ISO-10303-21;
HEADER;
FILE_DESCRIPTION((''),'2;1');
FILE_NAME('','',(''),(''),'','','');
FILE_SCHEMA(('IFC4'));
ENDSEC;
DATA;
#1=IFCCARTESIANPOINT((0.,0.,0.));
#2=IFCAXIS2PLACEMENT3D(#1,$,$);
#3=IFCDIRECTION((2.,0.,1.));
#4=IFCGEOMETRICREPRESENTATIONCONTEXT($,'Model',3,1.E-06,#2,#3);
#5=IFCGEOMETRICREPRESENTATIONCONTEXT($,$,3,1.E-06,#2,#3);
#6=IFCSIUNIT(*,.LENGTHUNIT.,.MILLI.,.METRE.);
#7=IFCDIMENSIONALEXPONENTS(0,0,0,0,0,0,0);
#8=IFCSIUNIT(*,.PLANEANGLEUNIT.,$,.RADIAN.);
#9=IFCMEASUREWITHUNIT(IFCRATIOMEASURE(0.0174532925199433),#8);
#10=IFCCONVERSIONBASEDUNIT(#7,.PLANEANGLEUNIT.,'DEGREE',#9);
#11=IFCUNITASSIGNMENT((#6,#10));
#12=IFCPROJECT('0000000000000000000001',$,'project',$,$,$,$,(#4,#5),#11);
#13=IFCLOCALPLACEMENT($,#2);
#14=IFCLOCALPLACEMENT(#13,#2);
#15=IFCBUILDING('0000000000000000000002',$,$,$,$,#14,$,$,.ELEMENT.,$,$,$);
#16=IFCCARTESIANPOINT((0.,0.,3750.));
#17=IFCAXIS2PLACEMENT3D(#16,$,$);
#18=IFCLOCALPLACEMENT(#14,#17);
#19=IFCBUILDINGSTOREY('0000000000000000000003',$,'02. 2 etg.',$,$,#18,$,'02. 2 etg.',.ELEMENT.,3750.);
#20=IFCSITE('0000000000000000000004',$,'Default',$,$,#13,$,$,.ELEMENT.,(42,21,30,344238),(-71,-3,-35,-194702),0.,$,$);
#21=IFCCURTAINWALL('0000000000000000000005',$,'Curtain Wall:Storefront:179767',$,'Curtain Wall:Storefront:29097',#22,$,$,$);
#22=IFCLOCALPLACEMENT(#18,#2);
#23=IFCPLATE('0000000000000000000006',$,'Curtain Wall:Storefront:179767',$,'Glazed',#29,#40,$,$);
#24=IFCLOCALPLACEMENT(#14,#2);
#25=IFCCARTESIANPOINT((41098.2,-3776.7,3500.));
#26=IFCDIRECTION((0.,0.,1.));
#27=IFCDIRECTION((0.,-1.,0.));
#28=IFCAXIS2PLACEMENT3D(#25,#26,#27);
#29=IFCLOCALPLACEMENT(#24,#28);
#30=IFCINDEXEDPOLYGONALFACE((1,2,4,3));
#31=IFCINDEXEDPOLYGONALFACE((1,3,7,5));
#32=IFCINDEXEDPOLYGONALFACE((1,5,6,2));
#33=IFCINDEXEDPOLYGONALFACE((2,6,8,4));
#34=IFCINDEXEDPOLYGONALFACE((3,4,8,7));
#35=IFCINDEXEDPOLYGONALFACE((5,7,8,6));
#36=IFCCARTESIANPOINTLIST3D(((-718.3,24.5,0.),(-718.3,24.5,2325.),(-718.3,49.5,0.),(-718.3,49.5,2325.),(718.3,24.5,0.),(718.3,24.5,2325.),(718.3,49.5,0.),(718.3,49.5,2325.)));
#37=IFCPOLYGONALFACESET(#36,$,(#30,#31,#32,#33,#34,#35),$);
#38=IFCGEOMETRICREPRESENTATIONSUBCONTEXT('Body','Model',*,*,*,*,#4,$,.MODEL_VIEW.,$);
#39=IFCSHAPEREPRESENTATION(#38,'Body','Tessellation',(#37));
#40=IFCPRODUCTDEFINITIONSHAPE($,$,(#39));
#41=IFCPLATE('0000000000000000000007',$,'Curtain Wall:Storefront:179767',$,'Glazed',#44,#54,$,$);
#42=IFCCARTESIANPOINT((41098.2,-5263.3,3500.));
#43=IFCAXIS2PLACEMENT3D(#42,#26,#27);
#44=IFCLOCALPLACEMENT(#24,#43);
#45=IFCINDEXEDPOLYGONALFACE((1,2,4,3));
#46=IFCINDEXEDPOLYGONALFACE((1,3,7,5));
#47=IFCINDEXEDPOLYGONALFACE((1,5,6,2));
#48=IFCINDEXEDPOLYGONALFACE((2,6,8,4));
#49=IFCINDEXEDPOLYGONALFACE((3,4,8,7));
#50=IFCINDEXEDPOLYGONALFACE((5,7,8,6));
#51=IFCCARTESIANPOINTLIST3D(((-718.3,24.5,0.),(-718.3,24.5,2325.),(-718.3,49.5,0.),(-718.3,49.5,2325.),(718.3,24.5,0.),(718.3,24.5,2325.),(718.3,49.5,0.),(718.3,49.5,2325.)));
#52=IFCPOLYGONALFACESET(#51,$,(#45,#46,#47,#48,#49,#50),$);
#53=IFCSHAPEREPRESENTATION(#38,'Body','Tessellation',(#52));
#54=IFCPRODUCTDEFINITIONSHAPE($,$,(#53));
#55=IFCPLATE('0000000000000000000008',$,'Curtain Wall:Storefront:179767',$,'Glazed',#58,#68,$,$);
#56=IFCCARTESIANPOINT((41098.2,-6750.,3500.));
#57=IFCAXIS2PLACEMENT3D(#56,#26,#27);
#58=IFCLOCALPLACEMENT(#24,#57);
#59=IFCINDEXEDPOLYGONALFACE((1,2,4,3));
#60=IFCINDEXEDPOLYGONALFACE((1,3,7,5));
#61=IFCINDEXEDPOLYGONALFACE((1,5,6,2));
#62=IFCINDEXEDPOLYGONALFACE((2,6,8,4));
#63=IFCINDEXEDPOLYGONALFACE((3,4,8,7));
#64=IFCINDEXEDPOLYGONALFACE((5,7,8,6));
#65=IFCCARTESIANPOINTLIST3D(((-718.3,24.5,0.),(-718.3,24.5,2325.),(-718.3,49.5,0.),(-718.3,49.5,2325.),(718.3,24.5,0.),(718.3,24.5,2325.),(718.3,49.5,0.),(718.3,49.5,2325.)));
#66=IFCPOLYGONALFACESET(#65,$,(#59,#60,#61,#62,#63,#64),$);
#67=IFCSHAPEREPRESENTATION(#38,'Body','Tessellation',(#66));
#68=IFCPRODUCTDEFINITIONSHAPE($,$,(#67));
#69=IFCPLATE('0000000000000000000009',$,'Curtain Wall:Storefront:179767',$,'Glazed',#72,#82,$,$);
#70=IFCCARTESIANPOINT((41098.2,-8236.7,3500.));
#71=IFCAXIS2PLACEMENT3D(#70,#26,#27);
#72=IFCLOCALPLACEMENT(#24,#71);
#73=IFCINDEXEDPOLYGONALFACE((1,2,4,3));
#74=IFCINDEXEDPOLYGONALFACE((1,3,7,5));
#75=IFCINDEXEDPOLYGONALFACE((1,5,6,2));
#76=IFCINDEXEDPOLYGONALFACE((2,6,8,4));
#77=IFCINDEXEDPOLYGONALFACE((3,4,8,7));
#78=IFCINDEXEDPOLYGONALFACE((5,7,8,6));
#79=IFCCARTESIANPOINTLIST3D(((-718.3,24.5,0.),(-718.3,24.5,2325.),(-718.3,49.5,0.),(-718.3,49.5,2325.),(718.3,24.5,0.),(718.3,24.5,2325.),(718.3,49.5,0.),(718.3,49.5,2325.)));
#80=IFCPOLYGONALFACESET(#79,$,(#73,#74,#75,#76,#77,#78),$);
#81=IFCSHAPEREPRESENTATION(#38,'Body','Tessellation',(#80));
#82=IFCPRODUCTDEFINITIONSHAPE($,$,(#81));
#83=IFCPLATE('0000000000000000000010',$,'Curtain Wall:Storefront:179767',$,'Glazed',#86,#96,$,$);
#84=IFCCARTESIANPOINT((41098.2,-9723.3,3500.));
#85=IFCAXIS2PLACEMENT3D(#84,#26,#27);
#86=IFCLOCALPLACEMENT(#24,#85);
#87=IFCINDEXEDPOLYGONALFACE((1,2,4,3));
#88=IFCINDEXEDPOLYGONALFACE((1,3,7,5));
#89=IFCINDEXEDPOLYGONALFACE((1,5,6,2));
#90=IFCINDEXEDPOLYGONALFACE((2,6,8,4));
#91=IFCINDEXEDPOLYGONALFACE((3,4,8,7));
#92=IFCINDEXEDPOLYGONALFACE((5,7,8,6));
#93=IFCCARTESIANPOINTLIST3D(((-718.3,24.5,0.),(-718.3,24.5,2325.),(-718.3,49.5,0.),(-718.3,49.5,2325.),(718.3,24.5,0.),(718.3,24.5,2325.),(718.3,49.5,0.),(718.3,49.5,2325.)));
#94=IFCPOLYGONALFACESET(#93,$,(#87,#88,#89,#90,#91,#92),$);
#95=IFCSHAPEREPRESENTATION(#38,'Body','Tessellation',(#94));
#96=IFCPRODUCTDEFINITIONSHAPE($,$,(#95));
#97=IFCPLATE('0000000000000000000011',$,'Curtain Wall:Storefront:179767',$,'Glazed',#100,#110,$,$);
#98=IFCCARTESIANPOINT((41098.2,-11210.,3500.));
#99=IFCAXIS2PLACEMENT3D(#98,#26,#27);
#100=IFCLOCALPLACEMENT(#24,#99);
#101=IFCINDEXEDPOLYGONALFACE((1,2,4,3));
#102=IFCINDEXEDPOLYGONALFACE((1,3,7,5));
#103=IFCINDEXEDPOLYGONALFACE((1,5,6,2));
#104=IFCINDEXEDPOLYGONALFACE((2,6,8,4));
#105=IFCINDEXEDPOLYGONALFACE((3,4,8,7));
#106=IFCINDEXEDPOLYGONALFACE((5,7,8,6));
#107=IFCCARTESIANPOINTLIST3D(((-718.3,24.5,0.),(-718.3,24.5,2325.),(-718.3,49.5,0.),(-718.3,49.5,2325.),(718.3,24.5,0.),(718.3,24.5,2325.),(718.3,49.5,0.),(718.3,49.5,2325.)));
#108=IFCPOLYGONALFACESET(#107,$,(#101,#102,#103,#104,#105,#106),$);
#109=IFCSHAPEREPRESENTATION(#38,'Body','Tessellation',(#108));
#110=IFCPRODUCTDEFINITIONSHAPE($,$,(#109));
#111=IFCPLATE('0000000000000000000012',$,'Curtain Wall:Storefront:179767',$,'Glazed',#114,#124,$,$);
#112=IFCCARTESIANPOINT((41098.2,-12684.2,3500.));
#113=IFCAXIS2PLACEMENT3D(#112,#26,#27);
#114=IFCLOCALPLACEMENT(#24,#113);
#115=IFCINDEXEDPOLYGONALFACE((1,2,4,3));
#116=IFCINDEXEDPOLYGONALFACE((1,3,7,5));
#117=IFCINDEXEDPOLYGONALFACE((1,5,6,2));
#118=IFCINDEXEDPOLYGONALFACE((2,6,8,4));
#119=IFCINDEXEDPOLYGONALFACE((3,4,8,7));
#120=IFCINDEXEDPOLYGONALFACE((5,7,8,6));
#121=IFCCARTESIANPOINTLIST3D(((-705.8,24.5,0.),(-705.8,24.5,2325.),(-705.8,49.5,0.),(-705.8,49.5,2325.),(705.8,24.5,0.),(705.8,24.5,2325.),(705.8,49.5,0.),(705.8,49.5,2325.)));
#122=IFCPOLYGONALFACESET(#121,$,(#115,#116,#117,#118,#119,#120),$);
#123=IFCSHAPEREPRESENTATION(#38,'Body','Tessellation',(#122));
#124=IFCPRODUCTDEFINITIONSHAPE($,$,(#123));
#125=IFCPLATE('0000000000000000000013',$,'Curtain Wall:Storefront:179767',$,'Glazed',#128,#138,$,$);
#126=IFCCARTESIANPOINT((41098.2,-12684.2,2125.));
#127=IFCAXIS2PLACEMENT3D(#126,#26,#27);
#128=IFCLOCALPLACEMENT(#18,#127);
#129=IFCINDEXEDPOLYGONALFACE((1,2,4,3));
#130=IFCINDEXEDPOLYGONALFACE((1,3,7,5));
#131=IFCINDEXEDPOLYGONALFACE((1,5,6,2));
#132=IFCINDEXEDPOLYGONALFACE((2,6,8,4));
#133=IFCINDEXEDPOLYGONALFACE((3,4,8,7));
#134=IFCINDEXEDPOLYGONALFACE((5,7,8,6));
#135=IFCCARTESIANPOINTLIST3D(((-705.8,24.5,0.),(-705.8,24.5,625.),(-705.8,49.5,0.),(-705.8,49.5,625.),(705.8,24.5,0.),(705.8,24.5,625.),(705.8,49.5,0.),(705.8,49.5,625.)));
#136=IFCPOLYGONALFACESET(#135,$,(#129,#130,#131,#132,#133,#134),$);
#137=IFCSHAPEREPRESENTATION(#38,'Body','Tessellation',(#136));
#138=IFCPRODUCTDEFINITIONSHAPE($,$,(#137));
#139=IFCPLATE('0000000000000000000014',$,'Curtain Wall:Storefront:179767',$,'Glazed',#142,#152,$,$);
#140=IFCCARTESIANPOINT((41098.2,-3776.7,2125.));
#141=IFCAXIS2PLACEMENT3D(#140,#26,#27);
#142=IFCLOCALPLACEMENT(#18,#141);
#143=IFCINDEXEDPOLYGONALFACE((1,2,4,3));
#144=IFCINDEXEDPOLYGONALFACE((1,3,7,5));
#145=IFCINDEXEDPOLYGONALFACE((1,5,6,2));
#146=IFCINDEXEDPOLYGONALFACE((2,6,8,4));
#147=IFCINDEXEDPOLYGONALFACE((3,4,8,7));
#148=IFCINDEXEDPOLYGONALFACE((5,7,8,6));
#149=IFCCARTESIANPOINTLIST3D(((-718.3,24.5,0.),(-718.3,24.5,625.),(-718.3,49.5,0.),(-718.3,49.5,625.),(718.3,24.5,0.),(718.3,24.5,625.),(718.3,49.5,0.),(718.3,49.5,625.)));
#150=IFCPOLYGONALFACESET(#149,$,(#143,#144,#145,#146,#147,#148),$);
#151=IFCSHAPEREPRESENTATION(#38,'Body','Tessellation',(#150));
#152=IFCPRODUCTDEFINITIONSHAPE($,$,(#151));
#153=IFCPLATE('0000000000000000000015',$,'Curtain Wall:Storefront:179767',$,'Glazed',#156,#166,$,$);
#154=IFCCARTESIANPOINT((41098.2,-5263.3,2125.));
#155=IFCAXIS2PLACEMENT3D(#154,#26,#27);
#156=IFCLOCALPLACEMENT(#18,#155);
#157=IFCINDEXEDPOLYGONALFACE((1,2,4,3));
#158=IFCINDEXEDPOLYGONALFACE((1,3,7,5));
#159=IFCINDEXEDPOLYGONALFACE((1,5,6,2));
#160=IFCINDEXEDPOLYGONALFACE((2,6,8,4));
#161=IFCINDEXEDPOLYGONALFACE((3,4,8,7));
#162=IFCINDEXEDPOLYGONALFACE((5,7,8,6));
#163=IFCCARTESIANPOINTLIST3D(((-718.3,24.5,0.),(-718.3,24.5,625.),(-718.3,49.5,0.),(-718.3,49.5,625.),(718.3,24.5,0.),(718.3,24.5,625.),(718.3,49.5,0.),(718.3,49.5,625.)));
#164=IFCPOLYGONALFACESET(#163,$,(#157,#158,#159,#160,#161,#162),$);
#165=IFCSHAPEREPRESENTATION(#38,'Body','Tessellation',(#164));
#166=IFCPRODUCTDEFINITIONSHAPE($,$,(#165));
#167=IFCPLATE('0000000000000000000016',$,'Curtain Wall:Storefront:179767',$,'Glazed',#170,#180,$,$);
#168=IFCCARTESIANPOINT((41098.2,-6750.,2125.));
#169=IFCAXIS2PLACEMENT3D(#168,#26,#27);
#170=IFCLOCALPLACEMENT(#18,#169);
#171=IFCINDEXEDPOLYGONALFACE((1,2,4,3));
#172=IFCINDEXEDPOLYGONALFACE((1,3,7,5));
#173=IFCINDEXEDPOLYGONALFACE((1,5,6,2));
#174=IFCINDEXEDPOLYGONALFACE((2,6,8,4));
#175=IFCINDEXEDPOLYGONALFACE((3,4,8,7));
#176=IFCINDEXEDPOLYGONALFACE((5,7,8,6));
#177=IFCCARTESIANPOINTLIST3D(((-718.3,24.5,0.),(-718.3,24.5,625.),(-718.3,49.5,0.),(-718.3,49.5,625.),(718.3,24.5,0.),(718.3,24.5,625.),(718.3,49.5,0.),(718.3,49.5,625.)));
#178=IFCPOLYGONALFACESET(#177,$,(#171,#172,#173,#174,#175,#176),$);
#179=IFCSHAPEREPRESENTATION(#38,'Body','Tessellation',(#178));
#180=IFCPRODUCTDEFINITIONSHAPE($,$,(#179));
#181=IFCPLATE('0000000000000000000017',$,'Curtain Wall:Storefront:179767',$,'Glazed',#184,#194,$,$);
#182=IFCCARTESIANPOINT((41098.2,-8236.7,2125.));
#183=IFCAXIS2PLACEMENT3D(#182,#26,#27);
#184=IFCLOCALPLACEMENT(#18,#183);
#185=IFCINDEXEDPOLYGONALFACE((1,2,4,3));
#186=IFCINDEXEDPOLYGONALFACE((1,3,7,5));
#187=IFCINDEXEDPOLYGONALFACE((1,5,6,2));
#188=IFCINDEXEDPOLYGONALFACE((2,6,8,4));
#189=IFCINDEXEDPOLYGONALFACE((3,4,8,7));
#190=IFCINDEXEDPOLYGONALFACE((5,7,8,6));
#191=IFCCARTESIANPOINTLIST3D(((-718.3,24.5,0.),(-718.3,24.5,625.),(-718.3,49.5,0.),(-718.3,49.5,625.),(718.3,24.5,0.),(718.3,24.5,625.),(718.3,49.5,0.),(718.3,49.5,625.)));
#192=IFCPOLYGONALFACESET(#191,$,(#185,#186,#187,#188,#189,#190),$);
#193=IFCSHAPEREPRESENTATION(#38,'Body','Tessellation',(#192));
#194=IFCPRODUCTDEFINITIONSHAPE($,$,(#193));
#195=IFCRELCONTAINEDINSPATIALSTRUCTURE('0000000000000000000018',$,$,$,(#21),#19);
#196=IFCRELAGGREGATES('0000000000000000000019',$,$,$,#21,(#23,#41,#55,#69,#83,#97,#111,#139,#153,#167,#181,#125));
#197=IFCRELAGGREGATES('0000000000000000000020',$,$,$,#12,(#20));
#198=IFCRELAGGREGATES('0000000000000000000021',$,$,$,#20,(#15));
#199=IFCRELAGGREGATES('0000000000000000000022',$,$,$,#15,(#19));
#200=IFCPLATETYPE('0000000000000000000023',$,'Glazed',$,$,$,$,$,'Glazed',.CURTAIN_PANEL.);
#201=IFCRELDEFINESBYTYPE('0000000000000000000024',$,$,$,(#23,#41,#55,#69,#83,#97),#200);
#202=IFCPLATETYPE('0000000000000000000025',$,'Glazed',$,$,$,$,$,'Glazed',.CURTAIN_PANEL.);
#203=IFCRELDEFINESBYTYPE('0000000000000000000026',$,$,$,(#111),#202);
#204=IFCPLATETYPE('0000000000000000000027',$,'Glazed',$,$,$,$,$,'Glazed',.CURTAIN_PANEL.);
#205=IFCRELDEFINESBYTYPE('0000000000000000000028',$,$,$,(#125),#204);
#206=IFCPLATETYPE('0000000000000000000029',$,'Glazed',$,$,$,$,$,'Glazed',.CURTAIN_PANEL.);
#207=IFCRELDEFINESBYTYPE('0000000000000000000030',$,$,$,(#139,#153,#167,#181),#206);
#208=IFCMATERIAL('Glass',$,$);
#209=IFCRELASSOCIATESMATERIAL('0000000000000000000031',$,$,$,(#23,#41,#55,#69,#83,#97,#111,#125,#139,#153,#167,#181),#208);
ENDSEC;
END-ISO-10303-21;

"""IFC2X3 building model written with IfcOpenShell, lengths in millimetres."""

from ifc_helpers import new_model, entity, si_unit, converted_unit, direction, frame, origin, origin_2d_with_axis, place, context, subcontext, project, spatial, rectangle, extrude, source, transform, mapped, material, type_object, type_shapes, element, aggregate, save


model = new_model("IFC2X3")

# Units and contexts
model_context = context("Model", 3, precision=1e-06, world=origin(), true_north=direction((2.0, 0.0, 1.0)))
context_of_model = context(None, 3, precision=1e-06, world=origin(), true_north=direction((2.0, 0.0, 1.0)))
body_context = subcontext(model_context, "Body", "Model", "MODEL_VIEW")
ifc_project = project(units=[si_unit("LENGTHUNIT", "METRE", prefix="MILLI"), converted_unit("PLANEANGLEUNIT", "DEGREE", entity("IfcRatioMeasure", 0.0174532925199433), si_unit("PLANEANGLEUNIT", "RADIAN"), dimensions=[0, 0, 0, 0, 0, 0, 0])], contexts=[model_context, context_of_model])

# Site, building, storey
site_placement = place(None, origin())
site = spatial("IfcSite", under=ifc_project, at=site_placement, Name="Default", CompositionType="ELEMENT", RefLatitude=(42, 21, 30, 344238), RefLongitude=(-71, -3, -35, -194702), RefElevation=0.0)
building_placement = place(site_placement, origin())
building = spatial("IfcBuilding", under=site, at=building_placement, CompositionType="ELEMENT")
storey_placement = place(building_placement, frame((0.0, 0.0, 3750.0)))
storey = spatial("IfcBuildingStorey", under=building, at=storey_placement, Name="02. 2 etg.", LongName="02. 2 etg.", CompositionType="ELEMENT", Elevation=3750.0)

# Curtain wall, plates
curtain_wall_1_placement = place(storey_placement, origin())
curtain_wall_1 = element("IfcCurtainWall", 1, at=curtain_wall_1_placement, inside=storey, Name="Curtain Wall:Storefront:179767", ObjectType="Curtain Wall:Storefront:29097")
ifc_material_1 = material(Name="Glass")
plate_type_1 = type_object("IfcPlateType", Name="Glazed", ElementType="Glazed", PredefinedType="CURTAIN_PANEL")
shared_shape_1 = source(origin(), body_context, "Body", "SweptSolid", [
    extrude(rectangle(XDim=25.0, YDim=1436.7, at=origin_2d_with_axis()), frame((0.0, 37.0, 0.0), z_axis=(0.0, 0.0, 1.0), x_axis=(0.0, 1.0, 0.0)), (0.0, 0.0, 1.0), 2325.0),
])
type_shapes(plate_type_1, [shared_shape_1])
placement = place(building_placement, origin())
plate_1_placement = place(placement, frame((41098.2, -3776.7, 3500.0), z_axis=(0.0, 0.0, 1.0), x_axis=(0.0, -1.0, 0.0)))
plate_1 = element("IfcPlate", 2, at=plate_1_placement, type_object=plate_type_1, material=ifc_material_1, Name="Curtain Wall:Storefront:179767", ObjectType="Glazed", context=body_context, shape_type="MappedRepresentation", body=[
    mapped(shared_shape_1, transform((0.0, 0.0, 0.0), scale=1.0)),
])
plate_2_placement = place(placement, frame((41098.2, -5263.3, 3500.0), z_axis=(0.0, 0.0, 1.0), x_axis=(0.0, -1.0, 0.0)))
plate_2 = element("IfcPlate", 3, at=plate_2_placement, type_object=plate_type_1, material=ifc_material_1, Name="Curtain Wall:Storefront:179767", ObjectType="Glazed", context=body_context, shape_type="MappedRepresentation", body=[
    mapped(shared_shape_1, transform((0.0, 0.0, 0.0), scale=1.0)),
])
plate_3_placement = place(placement, frame((41098.2, -6750.0, 3500.0), z_axis=(0.0, 0.0, 1.0), x_axis=(0.0, -1.0, 0.0)))
plate_3 = element("IfcPlate", 4, at=plate_3_placement, type_object=plate_type_1, material=ifc_material_1, Name="Curtain Wall:Storefront:179767", ObjectType="Glazed", context=body_context, shape_type="MappedRepresentation", body=[
    mapped(shared_shape_1, transform((0.0, 0.0, 0.0), scale=1.0)),
])
plate_4_placement = place(placement, frame((41098.2, -8236.7, 3500.0), z_axis=(0.0, 0.0, 1.0), x_axis=(0.0, -1.0, 0.0)))
plate_4 = element("IfcPlate", 5, at=plate_4_placement, type_object=plate_type_1, material=ifc_material_1, Name="Curtain Wall:Storefront:179767", ObjectType="Glazed", context=body_context, shape_type="MappedRepresentation", body=[
    mapped(shared_shape_1, transform((0.0, 0.0, 0.0), scale=1.0)),
])
plate_5_placement = place(placement, frame((41098.2, -9723.3, 3500.0), z_axis=(0.0, 0.0, 1.0), x_axis=(0.0, -1.0, 0.0)))
plate_5 = element("IfcPlate", 6, at=plate_5_placement, type_object=plate_type_1, material=ifc_material_1, Name="Curtain Wall:Storefront:179767", ObjectType="Glazed", context=body_context, shape_type="MappedRepresentation", body=[
    mapped(shared_shape_1, transform((0.0, 0.0, 0.0), scale=1.0)),
])
plate_6_placement = place(placement, frame((41098.2, -11210.0, 3500.0), z_axis=(0.0, 0.0, 1.0), x_axis=(0.0, -1.0, 0.0)))
plate_6 = element("IfcPlate", 7, at=plate_6_placement, type_object=plate_type_1, material=ifc_material_1, Name="Curtain Wall:Storefront:179767", ObjectType="Glazed", context=body_context, shape_type="MappedRepresentation", body=[
    mapped(shared_shape_1, transform((0.0, 0.0, 0.0), scale=1.0)),
])
plate_type_2 = type_object("IfcPlateType", Name="Glazed", ElementType="Glazed", PredefinedType="CURTAIN_PANEL")
shared_shape_2 = source(origin(), body_context, "Body", "SweptSolid", [
    extrude(rectangle(XDim=25.0, YDim=1411.7, at=origin_2d_with_axis()), frame((0.0, 37.0, 0.0), z_axis=(0.0, 0.0, 1.0), x_axis=(0.0, 1.0, 0.0)), (0.0, 0.0, 1.0), 2325.0),
])
type_shapes(plate_type_2, [shared_shape_2])
plate_7_placement = place(placement, frame((41098.2, -12684.2, 3500.0), z_axis=(0.0, 0.0, 1.0), x_axis=(0.0, -1.0, 0.0)))
plate_7 = element("IfcPlate", 8, at=plate_7_placement, type_object=plate_type_2, material=ifc_material_1, Name="Curtain Wall:Storefront:179767", ObjectType="Glazed", context=body_context, shape_type="MappedRepresentation", body=[
    mapped(shared_shape_2, transform((0.0, 0.0, 0.0), scale=1.0)),
])
plate_type_3 = type_object("IfcPlateType", Name="Glazed", ElementType="Glazed", PredefinedType="CURTAIN_PANEL")
shared_shape_3 = source(origin(), body_context, "Body", "SweptSolid", [
    extrude(rectangle(XDim=25.0, YDim=1411.7, at=origin_2d_with_axis()), frame((0.0, 37.0, 0.0), z_axis=(0.0, 0.0, 1.0), x_axis=(0.0, 1.0, 0.0)), (0.0, 0.0, 1.0), 625.0),
])
type_shapes(plate_type_3, [shared_shape_3])
plate_8_placement = place(storey_placement, frame((41098.2, -12684.2, 2125.0), z_axis=(0.0, 0.0, 1.0), x_axis=(0.0, -1.0, 0.0)))
plate_8 = element("IfcPlate", 9, at=plate_8_placement, type_object=plate_type_3, material=ifc_material_1, Name="Curtain Wall:Storefront:179767", ObjectType="Glazed", context=body_context, shape_type="MappedRepresentation", body=[
    mapped(shared_shape_3, transform((0.0, 0.0, 0.0), scale=1.0)),
])
plate_type_4 = type_object("IfcPlateType", Name="Glazed", ElementType="Glazed", PredefinedType="CURTAIN_PANEL")
shared_shape_4 = source(origin(), body_context, "Body", "SweptSolid", [
    extrude(rectangle(XDim=25.0, YDim=1436.7, at=origin_2d_with_axis()), frame((0.0, 37.0, 0.0), z_axis=(0.0, 0.0, 1.0), x_axis=(0.0, 1.0, 0.0)), (0.0, 0.0, 1.0), 625.0),
])
type_shapes(plate_type_4, [shared_shape_4])
plate_9_placement = place(storey_placement, frame((41098.2, -3776.7, 2125.0), z_axis=(0.0, 0.0, 1.0), x_axis=(0.0, -1.0, 0.0)))
plate_9 = element("IfcPlate", 10, at=plate_9_placement, type_object=plate_type_4, material=ifc_material_1, Name="Curtain Wall:Storefront:179767", ObjectType="Glazed", context=body_context, shape_type="MappedRepresentation", body=[
    mapped(shared_shape_4, transform((0.0, 0.0, 0.0), scale=1.0)),
])
plate_10_placement = place(storey_placement, frame((41098.2, -5263.3, 2125.0), z_axis=(0.0, 0.0, 1.0), x_axis=(0.0, -1.0, 0.0)))
plate_10 = element("IfcPlate", 11, at=plate_10_placement, type_object=plate_type_4, material=ifc_material_1, Name="Curtain Wall:Storefront:179767", ObjectType="Glazed", context=body_context, shape_type="MappedRepresentation", body=[
    mapped(shared_shape_4, transform((0.0, 0.0, 0.0), scale=1.0)),
])
plate_11_placement = place(storey_placement, frame((41098.2, -6750.0, 2125.0), z_axis=(0.0, 0.0, 1.0), x_axis=(0.0, -1.0, 0.0)))
plate_11 = element("IfcPlate", 12, at=plate_11_placement, type_object=plate_type_4, material=ifc_material_1, Name="Curtain Wall:Storefront:179767", ObjectType="Glazed", context=body_context, shape_type="MappedRepresentation", body=[
    mapped(shared_shape_4, transform((0.0, 0.0, 0.0), scale=1.0)),
])
plate_12_placement = place(storey_placement, frame((41098.2, -8236.7, 2125.0), z_axis=(0.0, 0.0, 1.0), x_axis=(0.0, -1.0, 0.0)))
plate_12 = element("IfcPlate", 13, at=plate_12_placement, type_object=plate_type_4, material=ifc_material_1, Name="Curtain Wall:Storefront:179767", ObjectType="Glazed", context=body_context, shape_type="MappedRepresentation", body=[
    mapped(shared_shape_4, transform((0.0, 0.0, 0.0), scale=1.0)),
])
aggregate(curtain_wall_1, [plate_1, plate_2, plate_3, plate_4, plate_5, plate_6, plate_7, plate_9, plate_10, plate_11, plate_12, plate_8])

save(model, "model.ifc")
